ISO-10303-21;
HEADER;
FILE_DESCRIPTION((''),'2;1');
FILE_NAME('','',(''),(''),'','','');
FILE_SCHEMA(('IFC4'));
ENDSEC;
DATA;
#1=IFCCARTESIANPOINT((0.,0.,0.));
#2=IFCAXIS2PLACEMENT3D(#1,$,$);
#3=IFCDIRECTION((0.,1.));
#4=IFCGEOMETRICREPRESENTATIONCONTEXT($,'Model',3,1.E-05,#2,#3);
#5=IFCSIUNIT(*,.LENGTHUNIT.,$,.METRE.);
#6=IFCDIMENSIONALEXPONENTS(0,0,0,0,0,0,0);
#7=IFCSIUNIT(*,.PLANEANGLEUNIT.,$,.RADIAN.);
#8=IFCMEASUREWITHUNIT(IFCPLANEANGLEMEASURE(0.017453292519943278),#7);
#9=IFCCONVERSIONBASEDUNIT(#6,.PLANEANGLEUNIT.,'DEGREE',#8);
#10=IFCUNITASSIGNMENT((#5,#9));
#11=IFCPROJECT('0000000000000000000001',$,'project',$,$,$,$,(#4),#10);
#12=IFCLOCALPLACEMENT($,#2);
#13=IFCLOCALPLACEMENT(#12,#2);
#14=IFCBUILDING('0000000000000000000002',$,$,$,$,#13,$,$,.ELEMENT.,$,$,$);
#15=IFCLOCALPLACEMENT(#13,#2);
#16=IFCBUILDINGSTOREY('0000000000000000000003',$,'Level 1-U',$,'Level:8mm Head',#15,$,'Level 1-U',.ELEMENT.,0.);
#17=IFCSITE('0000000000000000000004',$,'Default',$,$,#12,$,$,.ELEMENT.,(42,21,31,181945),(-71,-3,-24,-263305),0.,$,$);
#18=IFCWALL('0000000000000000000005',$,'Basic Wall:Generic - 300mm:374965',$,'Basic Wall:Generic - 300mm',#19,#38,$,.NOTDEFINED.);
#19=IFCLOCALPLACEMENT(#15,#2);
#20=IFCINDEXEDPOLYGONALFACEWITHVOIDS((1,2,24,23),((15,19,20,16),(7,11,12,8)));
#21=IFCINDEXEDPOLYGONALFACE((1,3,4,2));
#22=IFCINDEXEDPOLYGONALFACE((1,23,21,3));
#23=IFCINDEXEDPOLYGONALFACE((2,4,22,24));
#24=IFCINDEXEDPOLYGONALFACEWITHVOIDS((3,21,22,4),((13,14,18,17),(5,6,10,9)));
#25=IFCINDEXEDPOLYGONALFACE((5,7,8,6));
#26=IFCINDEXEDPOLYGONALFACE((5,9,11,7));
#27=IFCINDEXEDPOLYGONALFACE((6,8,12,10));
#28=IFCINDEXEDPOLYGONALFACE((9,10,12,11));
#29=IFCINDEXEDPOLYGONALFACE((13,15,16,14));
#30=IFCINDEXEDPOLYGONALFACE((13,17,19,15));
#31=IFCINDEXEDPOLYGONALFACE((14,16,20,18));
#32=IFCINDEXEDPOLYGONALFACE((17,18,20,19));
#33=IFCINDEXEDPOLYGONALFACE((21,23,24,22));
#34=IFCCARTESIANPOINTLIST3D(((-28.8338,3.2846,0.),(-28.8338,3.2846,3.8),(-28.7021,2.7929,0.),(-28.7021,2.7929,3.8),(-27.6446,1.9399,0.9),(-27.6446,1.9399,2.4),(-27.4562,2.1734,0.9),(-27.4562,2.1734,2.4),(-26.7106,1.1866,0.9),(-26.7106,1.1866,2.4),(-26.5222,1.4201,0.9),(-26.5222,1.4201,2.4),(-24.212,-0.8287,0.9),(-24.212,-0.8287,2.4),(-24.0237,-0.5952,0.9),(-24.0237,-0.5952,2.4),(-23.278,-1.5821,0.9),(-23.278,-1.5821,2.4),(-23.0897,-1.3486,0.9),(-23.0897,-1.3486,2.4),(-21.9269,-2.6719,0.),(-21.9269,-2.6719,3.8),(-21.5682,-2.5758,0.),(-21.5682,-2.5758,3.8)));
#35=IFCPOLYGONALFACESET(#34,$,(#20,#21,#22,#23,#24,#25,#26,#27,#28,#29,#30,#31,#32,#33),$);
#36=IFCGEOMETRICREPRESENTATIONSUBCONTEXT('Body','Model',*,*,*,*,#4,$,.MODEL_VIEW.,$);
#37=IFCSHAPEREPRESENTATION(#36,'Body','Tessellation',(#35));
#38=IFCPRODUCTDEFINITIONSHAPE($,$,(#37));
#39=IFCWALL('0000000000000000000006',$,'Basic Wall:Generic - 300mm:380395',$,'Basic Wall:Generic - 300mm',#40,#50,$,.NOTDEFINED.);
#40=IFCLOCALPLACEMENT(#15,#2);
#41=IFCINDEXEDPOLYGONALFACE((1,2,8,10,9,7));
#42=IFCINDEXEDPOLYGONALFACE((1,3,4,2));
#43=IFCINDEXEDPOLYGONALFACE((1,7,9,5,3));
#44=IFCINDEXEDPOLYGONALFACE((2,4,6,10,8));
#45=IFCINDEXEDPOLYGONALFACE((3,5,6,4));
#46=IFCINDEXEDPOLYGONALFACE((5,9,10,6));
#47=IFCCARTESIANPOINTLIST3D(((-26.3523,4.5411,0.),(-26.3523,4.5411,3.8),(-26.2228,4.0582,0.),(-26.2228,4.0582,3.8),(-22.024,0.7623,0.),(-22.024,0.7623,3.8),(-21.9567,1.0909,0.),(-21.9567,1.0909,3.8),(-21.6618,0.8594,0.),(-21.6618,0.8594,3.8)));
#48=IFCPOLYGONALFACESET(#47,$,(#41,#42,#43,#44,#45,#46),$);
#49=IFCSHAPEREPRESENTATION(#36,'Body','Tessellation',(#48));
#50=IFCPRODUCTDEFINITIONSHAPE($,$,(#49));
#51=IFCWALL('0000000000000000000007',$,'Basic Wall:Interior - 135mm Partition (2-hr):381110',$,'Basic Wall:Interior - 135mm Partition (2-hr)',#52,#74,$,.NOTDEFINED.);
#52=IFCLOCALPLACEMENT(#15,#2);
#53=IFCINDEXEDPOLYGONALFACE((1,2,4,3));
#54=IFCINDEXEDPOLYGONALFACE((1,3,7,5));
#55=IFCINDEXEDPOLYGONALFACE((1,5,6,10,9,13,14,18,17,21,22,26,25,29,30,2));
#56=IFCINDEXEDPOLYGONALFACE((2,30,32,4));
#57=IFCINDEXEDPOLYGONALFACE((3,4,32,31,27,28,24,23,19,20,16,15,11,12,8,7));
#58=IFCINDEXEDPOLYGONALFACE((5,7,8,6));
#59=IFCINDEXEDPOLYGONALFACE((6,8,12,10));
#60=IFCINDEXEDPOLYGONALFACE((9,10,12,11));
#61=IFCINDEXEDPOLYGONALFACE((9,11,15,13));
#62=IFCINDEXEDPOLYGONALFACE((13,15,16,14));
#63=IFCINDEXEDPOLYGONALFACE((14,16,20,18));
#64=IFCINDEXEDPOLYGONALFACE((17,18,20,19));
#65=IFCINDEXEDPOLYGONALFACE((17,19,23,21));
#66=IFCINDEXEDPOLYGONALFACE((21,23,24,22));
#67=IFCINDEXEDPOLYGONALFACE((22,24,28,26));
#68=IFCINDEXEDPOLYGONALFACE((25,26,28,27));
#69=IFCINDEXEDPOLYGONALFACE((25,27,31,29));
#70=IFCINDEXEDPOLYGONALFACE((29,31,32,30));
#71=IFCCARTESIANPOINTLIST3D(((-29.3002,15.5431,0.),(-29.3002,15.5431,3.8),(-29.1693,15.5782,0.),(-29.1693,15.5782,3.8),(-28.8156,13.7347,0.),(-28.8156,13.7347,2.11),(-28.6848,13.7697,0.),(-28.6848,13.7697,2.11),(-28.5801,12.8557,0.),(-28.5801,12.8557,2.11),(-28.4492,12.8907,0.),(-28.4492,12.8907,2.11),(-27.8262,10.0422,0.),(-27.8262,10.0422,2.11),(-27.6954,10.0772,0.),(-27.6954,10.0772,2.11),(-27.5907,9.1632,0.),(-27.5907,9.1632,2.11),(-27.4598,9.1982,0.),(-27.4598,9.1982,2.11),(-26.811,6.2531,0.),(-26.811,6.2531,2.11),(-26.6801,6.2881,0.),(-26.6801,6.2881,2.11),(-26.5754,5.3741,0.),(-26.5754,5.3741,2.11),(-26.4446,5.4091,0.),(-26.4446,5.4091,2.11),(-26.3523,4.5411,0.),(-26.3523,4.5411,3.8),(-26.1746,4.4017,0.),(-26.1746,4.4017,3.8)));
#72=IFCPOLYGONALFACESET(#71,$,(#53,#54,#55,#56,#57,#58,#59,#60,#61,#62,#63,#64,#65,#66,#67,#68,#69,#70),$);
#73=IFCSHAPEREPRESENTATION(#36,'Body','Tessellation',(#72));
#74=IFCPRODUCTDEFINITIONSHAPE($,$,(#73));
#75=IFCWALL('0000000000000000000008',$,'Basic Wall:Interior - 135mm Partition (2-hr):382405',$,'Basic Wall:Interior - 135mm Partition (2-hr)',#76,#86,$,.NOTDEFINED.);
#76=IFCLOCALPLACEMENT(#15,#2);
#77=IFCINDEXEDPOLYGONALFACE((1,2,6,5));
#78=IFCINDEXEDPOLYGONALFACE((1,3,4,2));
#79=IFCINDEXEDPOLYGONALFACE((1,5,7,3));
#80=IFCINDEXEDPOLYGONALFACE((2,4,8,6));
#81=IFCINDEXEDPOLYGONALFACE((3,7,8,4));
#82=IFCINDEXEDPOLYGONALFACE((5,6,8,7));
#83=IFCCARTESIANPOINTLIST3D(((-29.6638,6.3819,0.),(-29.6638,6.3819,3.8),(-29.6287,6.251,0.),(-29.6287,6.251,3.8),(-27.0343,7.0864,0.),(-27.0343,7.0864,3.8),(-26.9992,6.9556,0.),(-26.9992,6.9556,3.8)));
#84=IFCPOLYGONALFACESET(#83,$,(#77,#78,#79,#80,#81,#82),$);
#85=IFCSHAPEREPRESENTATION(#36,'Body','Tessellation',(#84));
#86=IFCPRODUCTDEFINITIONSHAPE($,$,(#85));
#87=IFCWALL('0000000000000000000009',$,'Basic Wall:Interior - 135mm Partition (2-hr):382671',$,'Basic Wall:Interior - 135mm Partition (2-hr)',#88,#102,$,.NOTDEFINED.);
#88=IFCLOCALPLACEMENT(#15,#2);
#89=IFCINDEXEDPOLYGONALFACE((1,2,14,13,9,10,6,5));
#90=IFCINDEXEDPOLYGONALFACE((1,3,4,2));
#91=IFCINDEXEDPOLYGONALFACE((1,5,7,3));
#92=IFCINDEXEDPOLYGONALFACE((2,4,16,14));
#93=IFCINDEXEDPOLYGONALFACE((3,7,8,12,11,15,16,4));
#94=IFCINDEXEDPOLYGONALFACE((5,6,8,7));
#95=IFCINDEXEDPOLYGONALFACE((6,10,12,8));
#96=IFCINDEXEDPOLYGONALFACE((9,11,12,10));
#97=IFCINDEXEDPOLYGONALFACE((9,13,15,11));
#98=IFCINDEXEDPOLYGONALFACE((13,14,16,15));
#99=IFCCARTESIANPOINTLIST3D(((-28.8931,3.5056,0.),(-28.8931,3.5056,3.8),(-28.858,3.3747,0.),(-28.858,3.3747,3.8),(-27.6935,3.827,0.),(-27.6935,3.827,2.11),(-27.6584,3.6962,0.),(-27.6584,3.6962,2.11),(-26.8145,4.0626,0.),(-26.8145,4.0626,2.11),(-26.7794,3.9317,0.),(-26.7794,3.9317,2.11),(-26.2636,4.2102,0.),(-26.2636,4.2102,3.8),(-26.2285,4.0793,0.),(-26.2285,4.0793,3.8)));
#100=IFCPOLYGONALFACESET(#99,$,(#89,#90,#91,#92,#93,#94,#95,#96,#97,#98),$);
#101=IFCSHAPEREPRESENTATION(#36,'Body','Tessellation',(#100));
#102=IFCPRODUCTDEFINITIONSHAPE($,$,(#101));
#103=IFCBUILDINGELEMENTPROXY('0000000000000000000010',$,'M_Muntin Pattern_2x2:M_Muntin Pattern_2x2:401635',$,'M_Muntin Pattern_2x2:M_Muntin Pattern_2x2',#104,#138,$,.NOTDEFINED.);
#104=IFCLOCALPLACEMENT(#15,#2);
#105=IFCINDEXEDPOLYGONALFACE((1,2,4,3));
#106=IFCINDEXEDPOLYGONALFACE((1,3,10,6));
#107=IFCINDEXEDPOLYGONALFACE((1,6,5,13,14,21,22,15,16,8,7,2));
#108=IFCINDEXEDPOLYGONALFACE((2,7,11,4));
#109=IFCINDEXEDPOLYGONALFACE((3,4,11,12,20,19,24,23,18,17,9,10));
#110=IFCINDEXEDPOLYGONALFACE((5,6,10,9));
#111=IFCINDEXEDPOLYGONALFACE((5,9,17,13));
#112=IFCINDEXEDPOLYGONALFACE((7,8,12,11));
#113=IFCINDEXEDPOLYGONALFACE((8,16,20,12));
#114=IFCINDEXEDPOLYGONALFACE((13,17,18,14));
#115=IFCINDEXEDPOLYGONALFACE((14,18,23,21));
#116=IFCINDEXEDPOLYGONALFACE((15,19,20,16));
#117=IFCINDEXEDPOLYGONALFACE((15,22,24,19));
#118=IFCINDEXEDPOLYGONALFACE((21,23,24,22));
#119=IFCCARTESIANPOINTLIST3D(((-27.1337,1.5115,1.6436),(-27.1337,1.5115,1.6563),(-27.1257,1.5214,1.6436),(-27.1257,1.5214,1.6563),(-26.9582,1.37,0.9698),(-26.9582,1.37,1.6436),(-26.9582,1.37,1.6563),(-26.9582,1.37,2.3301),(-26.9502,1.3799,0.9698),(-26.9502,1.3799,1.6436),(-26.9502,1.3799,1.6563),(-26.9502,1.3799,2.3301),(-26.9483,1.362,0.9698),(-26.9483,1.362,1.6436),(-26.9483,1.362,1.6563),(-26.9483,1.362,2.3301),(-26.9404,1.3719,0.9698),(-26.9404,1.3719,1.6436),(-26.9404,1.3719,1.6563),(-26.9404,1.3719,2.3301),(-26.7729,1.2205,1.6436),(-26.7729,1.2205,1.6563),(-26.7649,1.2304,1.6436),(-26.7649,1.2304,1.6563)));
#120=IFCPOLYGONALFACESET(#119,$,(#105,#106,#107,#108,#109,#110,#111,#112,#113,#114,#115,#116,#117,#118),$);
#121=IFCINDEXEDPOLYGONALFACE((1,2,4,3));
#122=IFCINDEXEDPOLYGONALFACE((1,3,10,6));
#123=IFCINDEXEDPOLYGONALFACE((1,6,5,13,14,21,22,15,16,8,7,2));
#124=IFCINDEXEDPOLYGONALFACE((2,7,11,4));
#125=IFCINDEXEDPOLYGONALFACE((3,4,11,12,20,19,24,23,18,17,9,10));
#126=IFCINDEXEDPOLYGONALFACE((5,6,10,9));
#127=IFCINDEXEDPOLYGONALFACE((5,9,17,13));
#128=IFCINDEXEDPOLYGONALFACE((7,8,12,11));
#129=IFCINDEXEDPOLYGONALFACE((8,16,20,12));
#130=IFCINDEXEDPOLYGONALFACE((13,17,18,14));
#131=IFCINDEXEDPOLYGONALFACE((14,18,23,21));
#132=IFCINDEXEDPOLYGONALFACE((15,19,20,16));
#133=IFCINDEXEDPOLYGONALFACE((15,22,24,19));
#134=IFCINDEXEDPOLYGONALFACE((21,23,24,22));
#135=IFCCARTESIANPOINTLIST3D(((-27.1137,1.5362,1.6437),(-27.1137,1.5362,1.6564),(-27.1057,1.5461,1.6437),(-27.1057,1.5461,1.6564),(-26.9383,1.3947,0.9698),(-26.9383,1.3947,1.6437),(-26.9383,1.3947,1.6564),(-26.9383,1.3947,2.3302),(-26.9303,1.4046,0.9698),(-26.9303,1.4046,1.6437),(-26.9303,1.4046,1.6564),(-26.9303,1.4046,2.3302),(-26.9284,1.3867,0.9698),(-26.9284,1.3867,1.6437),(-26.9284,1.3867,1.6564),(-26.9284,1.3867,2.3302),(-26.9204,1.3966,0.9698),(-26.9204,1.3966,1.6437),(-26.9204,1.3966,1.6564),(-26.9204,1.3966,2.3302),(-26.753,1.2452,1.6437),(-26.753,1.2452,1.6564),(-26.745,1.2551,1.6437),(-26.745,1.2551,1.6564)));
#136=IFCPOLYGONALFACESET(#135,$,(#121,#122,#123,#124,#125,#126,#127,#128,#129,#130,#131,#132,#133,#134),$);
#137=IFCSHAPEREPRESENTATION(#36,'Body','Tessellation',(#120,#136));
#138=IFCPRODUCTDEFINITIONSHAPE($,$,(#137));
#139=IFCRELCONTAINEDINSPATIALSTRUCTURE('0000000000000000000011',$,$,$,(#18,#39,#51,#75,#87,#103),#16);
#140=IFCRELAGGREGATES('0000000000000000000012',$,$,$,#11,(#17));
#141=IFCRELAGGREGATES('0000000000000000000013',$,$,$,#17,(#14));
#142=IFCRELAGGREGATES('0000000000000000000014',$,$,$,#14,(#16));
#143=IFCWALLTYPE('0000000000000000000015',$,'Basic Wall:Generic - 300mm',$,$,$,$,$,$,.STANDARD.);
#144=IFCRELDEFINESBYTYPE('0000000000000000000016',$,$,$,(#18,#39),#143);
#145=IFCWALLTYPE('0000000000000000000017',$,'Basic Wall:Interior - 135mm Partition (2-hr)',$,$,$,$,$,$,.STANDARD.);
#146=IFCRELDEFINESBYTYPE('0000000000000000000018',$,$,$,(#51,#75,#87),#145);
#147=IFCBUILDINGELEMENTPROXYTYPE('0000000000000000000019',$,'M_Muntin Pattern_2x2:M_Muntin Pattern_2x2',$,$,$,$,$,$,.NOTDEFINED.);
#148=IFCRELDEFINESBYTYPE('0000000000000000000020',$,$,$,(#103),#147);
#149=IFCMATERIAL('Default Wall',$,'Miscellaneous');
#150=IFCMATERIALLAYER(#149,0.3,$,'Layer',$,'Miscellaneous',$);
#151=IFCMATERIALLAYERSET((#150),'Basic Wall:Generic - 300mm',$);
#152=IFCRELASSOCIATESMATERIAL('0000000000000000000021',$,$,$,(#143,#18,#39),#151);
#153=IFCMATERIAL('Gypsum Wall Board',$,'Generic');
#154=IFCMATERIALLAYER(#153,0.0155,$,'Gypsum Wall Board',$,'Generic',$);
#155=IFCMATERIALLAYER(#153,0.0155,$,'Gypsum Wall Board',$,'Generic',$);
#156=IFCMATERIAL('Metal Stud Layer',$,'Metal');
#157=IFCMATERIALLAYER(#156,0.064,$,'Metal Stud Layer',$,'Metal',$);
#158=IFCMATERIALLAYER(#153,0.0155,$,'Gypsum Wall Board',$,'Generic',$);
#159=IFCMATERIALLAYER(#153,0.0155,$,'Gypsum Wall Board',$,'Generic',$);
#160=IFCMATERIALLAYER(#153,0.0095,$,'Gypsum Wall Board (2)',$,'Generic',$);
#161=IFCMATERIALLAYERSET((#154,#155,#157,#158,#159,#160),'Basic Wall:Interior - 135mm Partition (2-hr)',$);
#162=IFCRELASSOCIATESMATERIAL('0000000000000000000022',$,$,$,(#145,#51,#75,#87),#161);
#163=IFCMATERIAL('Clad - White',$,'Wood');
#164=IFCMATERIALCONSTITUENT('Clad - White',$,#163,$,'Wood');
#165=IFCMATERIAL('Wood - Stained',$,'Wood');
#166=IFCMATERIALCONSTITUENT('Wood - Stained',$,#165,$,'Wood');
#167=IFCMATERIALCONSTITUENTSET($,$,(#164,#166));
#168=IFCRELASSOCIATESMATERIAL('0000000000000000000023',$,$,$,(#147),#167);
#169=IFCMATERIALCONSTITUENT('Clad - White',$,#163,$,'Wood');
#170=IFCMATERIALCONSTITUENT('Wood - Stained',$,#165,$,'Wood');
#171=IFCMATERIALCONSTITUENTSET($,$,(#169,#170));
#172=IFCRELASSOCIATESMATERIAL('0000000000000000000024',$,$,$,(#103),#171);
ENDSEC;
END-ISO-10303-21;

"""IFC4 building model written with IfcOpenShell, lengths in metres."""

from ifc_helpers import new_model, entity, si_unit, converted_unit, direction, frame, frame_2d, origin, place, context, subcontext, project, spatial, polyline, rectangle, outline, extrude, source, transform, mapped, material, layer, layer_set, layer_usage, constituent, constituent_set, type_object, type_shapes, element, save


model = new_model("IFC4")

# Units and contexts
model_context = context("Model", 3, precision=1e-05, world=origin(), true_north=direction((0.0, 1.0)))
body_context = subcontext(model_context, "Body", "Model", "MODEL_VIEW")
ifc_project = project(units=[si_unit("LENGTHUNIT", "METRE"), converted_unit("PLANEANGLEUNIT", "DEGREE", entity("IfcPlaneAngleMeasure", 0.017453292519943278), si_unit("PLANEANGLEUNIT", "RADIAN"), dimensions=[0, 0, 0, 0, 0, 0, 0])], contexts=[model_context])

# Site, building, storey
site_placement = place(None, origin())
site = spatial("IfcSite", under=ifc_project, at=site_placement, Name="Default", CompositionType="ELEMENT", RefLatitude=(42, 21, 31, 181945), RefLongitude=(-71, -3, -24, -263305), RefElevation=0.0)
building_placement = place(site_placement, origin())
building = spatial("IfcBuilding", under=site, at=building_placement, CompositionType="ELEMENT")
storey_placement = place(building_placement, origin())
storey = spatial("IfcBuildingStorey", under=building, at=storey_placement, Name="Level 1-U", ObjectType="Level:8mm Head", LongName="Level 1-U", CompositionType="ELEMENT", Elevation=0.0)

# Wall, openings
ifc_material_1 = material(Name="Default Wall", Category="Miscellaneous")
ifc_layer_1 = layer(ifc_material_1, 0.3, Name="Layer", Category="Miscellaneous")
ifc_layer_set_1 = layer_set([ifc_layer_1], Name="Basic Wall:Generic - 300mm")
ifc_layer_usage_1 = layer_usage(ifc_layer_set_1, "AXIS2", "NEGATIVE", 0.15)
wall_type_1 = type_object("IfcWallType", Name="Basic Wall:Generic - 300mm", PredefinedType="STANDARD", material=ifc_layer_set_1)
wall_1_placement = place(storey_placement, frame((-28.928, 3.1679, 0.0), z_axis=(0.0, 0.0, 1.0), x_axis=(0.778359, -0.62782, 0.0)))
wall_1 = element("IfcWall", 1, at=wall_1_placement, inside=storey, type_object=wall_type_1, material=ifc_layer_usage_1, Name="Basic Wall:Generic - 300mm:374965", ObjectType="Basic Wall:Generic - 300mm", PredefinedType="NOTDEFINED", context=body_context, shape_type="SweptSolid", body=[
    extrude(outline(polyline([(9.1158, -0.15), (9.3346, 0.15), (0.0, 0.15), (0.4112, -0.15), (9.1158, -0.15)])), origin(), (0.0, 0.0, 1.0), 3.8),
])
opening_1_placement = place(wall_1_placement, frame((2.9699, 0.15, 0.9)))
element("IfcOpeningElement", 2, at=opening_1_placement, cuts=wall_1, PredefinedType="OPENING", context=body_context, shape_type="SweptSolid", body=[
    extrude(rectangle(XDim=1.5, YDim=1.2, at=frame_2d((0.75, 0.6), x_axis=(-1.0, 0.0))), frame((0.0, 0.0, 0.0), z_axis=(0.0, -1.0, 0.0), x_axis=(0.0, 0.0, 1.0)), (0.0, 0.0, 1.0), 0.3),
])
opening_2_placement = place(wall_1_placement, frame((7.3799, 0.15, 0.9)))
element("IfcOpeningElement", 3, at=opening_2_placement, cuts=wall_1, PredefinedType="OPENING", context=body_context, shape_type="SweptSolid", body=[
    extrude(rectangle(XDim=1.5, YDim=1.2, at=frame_2d((0.75, 0.6), x_axis=(-1.0, 0.0))), frame((0.0, 0.0, 0.0), z_axis=(0.0, -1.0, 0.0), x_axis=(0.0, 0.0, 1.0)), (0.0, 0.0, 1.0), 0.3),
])

# Wall
wall_2_placement = place(storey_placement, frame((-26.4449, 4.4232, 0.0), z_axis=(0.0, 0.0, 1.0), x_axis=(0.786611, -0.617449, 0.0)))
element("IfcWall", 4, at=wall_2_placement, inside=storey, type_object=wall_type_1, material=ifc_layer_usage_1, Name="Basic Wall:Generic - 300mm:380395", ObjectType="Basic Wall:Generic - 300mm", PredefinedType="NOTDEFINED", context=body_context, shape_type="SweptSolid", body=[
    extrude(outline(polyline([(5.7379, -0.15), (5.9629, 0.15), (5.5879, 0.15), (0.0, 0.15), (0.4, -0.15), (5.7379, -0.15)])), origin(), (0.0, 0.0, 1.0), 3.8),
])

# Wall, openings
ifc_material_2 = material(Name="Gypsum Wall Board", Category="Generic")
ifc_layer_2 = layer(ifc_material_2, 0.0155, Name="Gypsum Wall Board", Category="Generic")
ifc_layer_3 = layer(ifc_material_2, 0.0155, Name="Gypsum Wall Board", Category="Generic")
ifc_material_3 = material(Name="Metal Stud Layer", Category="Metal")
ifc_layer_4 = layer(ifc_material_3, 0.064, Name="Metal Stud Layer", Category="Metal")
ifc_layer_5 = layer(ifc_material_2, 0.0155, Name="Gypsum Wall Board", Category="Generic")
ifc_layer_6 = layer(ifc_material_2, 0.0155, Name="Gypsum Wall Board", Category="Generic")
ifc_layer_7 = layer(ifc_material_2, 0.0095, Name="Gypsum Wall Board (2)", Category="Generic")
ifc_layer_set_2 = layer_set([ifc_layer_2, ifc_layer_3, ifc_layer_4, ifc_layer_5, ifc_layer_6, ifc_layer_7], Name="Basic Wall:Interior - 135mm Partition (2-hr)")
ifc_layer_usage_2 = layer_usage(ifc_layer_set_2, "AXIS2", "NEGATIVE", 0.0677)
wall_type_2 = type_object("IfcWallType", Name="Basic Wall:Interior - 135mm Partition (2-hr)", PredefinedType="STANDARD", material=ifc_layer_set_2)
wall_3_placement = place(storey_placement, frame((-26.2401, 4.3842, 0.0), z_axis=(0.0, 0.0, 1.0), x_axis=(-0.258819, 0.965926, 0.0)))
wall_3 = element("IfcWall", 5, at=wall_3_placement, inside=storey, type_object=wall_type_2, material=ifc_layer_usage_2, Name="Basic Wall:Interior - 135mm Partition (2-hr):381110", ObjectType="Basic Wall:Interior - 135mm Partition (2-hr)", PredefinedType="NOTDEFINED", context=body_context, shape_type="SweptSolid", body=[
    extrude(outline(polyline([(0.0, -0.0677), (11.5707, -0.0677), (11.5707, 0.0678), (7.4885, 0.0678), (7.353, 0.0678), (2.8158, 0.0678), (2.6803, 0.0678), (0.1807, 0.0678), (0.0, -0.0677)])), origin(), (0.0, 0.0, 1.0), 3.8),
])
opening_3_placement = place(wall_3_placement, frame((9.6985, 0.0677, 0.0)))
element("IfcOpeningElement", 6, at=opening_3_placement, cuts=wall_3, PredefinedType="OPENING", context=body_context, shape_type="SweptSolid", body=[
    extrude(rectangle(XDim=2.11, YDim=0.91, at=frame_2d((1.055, 0.455), x_axis=(1.0, 0.0))), frame((0.0, 0.0, 0.0), z_axis=(0.0, -1.0, 0.0), x_axis=(0.0, 0.0, 1.0)), (0.0, 0.0, 1.0), 0.1355),
])
opening_4_placement = place(wall_3_placement, frame((5.8757, 0.0677, 0.0)))
element("IfcOpeningElement", 7, at=opening_4_placement, cuts=wall_3, PredefinedType="OPENING", context=body_context, shape_type="SweptSolid", body=[
    extrude(rectangle(XDim=2.11, YDim=0.91, at=frame_2d((1.055, 0.455), x_axis=(1.0, 0.0))), frame((0.0, 0.0, 0.0), z_axis=(0.0, -1.0, 0.0), x_axis=(0.0, 0.0, 1.0)), (0.0, 0.0, 1.0), 0.1355),
])
opening_5_placement = place(wall_3_placement, frame((1.953, 0.0677, 0.0)))
element("IfcOpeningElement", 8, at=opening_5_placement, cuts=wall_3, PredefinedType="OPENING", context=body_context, shape_type="SweptSolid", body=[
    extrude(rectangle(XDim=2.11, YDim=0.91, at=frame_2d((1.055, 0.455), x_axis=(1.0, 0.0))), frame((0.0, 0.0, 0.0), z_axis=(0.0, -1.0, 0.0), x_axis=(0.0, 0.0, 1.0)), (0.0, 0.0, 1.0), 0.1355),
])

# Wall
wall_4_placement = place(storey_placement, frame((-29.6462, 6.3164, 0.0), z_axis=(0.0, 0.0, 1.0), x_axis=(0.965926, 0.258819, 0.0)))
element("IfcWall", 9, at=wall_4_placement, inside=storey, type_object=wall_type_2, material=ifc_layer_usage_2, Name="Basic Wall:Interior - 135mm Partition (2-hr):382405", ObjectType="Basic Wall:Interior - 135mm Partition (2-hr)", PredefinedType="NOTDEFINED", context=body_context, shape_type="SweptSolid", body=[
    extrude(rectangle(XDim=2.7222, YDim=0.1355, at=frame_2d((1.3611, 0.0), x_axis=(-1.0, 0.0))), origin(), (0.0, 0.0, 1.0), 3.8),
])

# Wall, opening
wall_5_placement = place(storey_placement, frame((-26.246, 4.1447, 0.0), z_axis=(0.0, 0.0, 1.0), x_axis=(-0.965926, -0.258819, 0.0)))
wall_5 = element("IfcWall", 10, at=wall_5_placement, inside=storey, type_object=wall_type_2, material=ifc_layer_usage_2, Name="Basic Wall:Interior - 135mm Partition (2-hr):382671", ObjectType="Basic Wall:Interior - 135mm Partition (2-hr)", PredefinedType="NOTDEFINED", context=body_context, shape_type="SweptSolid", body=[
    extrude(rectangle(XDim=2.7222, YDim=0.1355, at=frame_2d((1.3611, 0.0), x_axis=(-1.0, 0.0))), origin(), (0.0, 0.0, 1.0), 3.8),
])
opening_6_placement = place(wall_5_placement, frame((0.5704, -0.0678, 0.0)))
element("IfcOpeningElement", 11, at=opening_6_placement, cuts=wall_5, PredefinedType="OPENING", context=body_context, shape_type="SweptSolid", body=[
    extrude(rectangle(XDim=2.11, YDim=0.91, at=frame_2d((1.055, 0.455), x_axis=(1.0, 0.0))), frame((0.0, 0.0, 0.0), z_axis=(0.0, 1.0, 0.0), x_axis=(0.0, 0.0, 1.0)), (0.0, 0.0, 1.0), 0.1355),
])

# Building element proxy
ifc_material_4 = material(Name="Clad - White", Category="Wood")
ifc_constituent_1 = constituent(ifc_material_4, Name="Clad - White", Category="Wood")
ifc_material_5 = material(Name="Wood - Stained", Category="Wood")
ifc_constituent_2 = constituent(ifc_material_5, Name="Wood - Stained", Category="Wood")
ifc_constituent_set_1 = constituent_set(constituents=[ifc_constituent_1, ifc_constituent_2])
ifc_constituent_3 = constituent(ifc_material_4, Name="Clad - White", Category="Wood")
ifc_constituent_4 = constituent(ifc_material_5, Name="Wood - Stained", Category="Wood")
ifc_constituent_set_2 = constituent_set(constituents=[ifc_constituent_3, ifc_constituent_4])
building_element_proxy_type_1 = type_object("IfcBuildingElementProxyType", Name="M_Muntin Pattern_2x2:M_Muntin Pattern_2x2", PredefinedType="NOTDEFINED", material=ifc_constituent_set_2)
shared_shape_1 = source(origin(), body_context, "Body", "SweptSolid", [
    extrude(outline(polyline([(0.0064, -0.0064), (0.6801, -0.0064), (0.6801, 0.0063), (0.0064, 0.0063), (0.0064, 0.2317), (-0.0063, 0.2317), (-0.0063, 0.0063), (-0.6802, 0.0063), (-0.6802, -0.0064), (-0.0063, -0.0064), (-0.0063, -0.2317), (0.0064, -0.2317), (0.0064, -0.0064)])), frame((0.0, 0.0095, 0.6801), z_axis=(0.0, 1.0, 0.0), x_axis=(0.0, 0.0, 1.0)), (0.0, 0.0, 1.0), 0.0127),
    extrude(outline(polyline([(0.0064, -0.0064), (0.6802, -0.0064), (0.6802, 0.0063), (0.0064, 0.0063), (0.0064, 0.2317), (-0.0063, 0.2317), (-0.0063, 0.0063), (-0.6802, 0.0063), (-0.6802, -0.0064), (-0.0063, -0.0064), (-0.0063, -0.2317), (0.0064, -0.2317), (0.0064, -0.0064)])), frame((0.0, -0.0222, 0.6802), z_axis=(0.0, 1.0, 0.0), x_axis=(0.0, 0.0, 1.0)), (0.0, 0.0, 1.0), 0.0127),
])
type_shapes(building_element_proxy_type_1, [shared_shape_1])
proxy_1_placement = place(storey_placement, frame((-26.9393, 1.3833, 0.9698), z_axis=(0.0, 0.0, 1.0), x_axis=(-0.778359, 0.62782, 0.0)))
element("IfcBuildingElementProxy", 12, at=proxy_1_placement, inside=storey, type_object=building_element_proxy_type_1, material=ifc_constituent_set_1, Name="M_Muntin Pattern_2x2:M_Muntin Pattern_2x2:401635", ObjectType="M_Muntin Pattern_2x2:M_Muntin Pattern_2x2", PredefinedType="NOTDEFINED", context=body_context, shape_type="MappedRepresentation", body=[
    mapped(shared_shape_1, transform((0.0, 0.0, 0.0), scale=1.0)),
])

save(model, "model.ifc")
